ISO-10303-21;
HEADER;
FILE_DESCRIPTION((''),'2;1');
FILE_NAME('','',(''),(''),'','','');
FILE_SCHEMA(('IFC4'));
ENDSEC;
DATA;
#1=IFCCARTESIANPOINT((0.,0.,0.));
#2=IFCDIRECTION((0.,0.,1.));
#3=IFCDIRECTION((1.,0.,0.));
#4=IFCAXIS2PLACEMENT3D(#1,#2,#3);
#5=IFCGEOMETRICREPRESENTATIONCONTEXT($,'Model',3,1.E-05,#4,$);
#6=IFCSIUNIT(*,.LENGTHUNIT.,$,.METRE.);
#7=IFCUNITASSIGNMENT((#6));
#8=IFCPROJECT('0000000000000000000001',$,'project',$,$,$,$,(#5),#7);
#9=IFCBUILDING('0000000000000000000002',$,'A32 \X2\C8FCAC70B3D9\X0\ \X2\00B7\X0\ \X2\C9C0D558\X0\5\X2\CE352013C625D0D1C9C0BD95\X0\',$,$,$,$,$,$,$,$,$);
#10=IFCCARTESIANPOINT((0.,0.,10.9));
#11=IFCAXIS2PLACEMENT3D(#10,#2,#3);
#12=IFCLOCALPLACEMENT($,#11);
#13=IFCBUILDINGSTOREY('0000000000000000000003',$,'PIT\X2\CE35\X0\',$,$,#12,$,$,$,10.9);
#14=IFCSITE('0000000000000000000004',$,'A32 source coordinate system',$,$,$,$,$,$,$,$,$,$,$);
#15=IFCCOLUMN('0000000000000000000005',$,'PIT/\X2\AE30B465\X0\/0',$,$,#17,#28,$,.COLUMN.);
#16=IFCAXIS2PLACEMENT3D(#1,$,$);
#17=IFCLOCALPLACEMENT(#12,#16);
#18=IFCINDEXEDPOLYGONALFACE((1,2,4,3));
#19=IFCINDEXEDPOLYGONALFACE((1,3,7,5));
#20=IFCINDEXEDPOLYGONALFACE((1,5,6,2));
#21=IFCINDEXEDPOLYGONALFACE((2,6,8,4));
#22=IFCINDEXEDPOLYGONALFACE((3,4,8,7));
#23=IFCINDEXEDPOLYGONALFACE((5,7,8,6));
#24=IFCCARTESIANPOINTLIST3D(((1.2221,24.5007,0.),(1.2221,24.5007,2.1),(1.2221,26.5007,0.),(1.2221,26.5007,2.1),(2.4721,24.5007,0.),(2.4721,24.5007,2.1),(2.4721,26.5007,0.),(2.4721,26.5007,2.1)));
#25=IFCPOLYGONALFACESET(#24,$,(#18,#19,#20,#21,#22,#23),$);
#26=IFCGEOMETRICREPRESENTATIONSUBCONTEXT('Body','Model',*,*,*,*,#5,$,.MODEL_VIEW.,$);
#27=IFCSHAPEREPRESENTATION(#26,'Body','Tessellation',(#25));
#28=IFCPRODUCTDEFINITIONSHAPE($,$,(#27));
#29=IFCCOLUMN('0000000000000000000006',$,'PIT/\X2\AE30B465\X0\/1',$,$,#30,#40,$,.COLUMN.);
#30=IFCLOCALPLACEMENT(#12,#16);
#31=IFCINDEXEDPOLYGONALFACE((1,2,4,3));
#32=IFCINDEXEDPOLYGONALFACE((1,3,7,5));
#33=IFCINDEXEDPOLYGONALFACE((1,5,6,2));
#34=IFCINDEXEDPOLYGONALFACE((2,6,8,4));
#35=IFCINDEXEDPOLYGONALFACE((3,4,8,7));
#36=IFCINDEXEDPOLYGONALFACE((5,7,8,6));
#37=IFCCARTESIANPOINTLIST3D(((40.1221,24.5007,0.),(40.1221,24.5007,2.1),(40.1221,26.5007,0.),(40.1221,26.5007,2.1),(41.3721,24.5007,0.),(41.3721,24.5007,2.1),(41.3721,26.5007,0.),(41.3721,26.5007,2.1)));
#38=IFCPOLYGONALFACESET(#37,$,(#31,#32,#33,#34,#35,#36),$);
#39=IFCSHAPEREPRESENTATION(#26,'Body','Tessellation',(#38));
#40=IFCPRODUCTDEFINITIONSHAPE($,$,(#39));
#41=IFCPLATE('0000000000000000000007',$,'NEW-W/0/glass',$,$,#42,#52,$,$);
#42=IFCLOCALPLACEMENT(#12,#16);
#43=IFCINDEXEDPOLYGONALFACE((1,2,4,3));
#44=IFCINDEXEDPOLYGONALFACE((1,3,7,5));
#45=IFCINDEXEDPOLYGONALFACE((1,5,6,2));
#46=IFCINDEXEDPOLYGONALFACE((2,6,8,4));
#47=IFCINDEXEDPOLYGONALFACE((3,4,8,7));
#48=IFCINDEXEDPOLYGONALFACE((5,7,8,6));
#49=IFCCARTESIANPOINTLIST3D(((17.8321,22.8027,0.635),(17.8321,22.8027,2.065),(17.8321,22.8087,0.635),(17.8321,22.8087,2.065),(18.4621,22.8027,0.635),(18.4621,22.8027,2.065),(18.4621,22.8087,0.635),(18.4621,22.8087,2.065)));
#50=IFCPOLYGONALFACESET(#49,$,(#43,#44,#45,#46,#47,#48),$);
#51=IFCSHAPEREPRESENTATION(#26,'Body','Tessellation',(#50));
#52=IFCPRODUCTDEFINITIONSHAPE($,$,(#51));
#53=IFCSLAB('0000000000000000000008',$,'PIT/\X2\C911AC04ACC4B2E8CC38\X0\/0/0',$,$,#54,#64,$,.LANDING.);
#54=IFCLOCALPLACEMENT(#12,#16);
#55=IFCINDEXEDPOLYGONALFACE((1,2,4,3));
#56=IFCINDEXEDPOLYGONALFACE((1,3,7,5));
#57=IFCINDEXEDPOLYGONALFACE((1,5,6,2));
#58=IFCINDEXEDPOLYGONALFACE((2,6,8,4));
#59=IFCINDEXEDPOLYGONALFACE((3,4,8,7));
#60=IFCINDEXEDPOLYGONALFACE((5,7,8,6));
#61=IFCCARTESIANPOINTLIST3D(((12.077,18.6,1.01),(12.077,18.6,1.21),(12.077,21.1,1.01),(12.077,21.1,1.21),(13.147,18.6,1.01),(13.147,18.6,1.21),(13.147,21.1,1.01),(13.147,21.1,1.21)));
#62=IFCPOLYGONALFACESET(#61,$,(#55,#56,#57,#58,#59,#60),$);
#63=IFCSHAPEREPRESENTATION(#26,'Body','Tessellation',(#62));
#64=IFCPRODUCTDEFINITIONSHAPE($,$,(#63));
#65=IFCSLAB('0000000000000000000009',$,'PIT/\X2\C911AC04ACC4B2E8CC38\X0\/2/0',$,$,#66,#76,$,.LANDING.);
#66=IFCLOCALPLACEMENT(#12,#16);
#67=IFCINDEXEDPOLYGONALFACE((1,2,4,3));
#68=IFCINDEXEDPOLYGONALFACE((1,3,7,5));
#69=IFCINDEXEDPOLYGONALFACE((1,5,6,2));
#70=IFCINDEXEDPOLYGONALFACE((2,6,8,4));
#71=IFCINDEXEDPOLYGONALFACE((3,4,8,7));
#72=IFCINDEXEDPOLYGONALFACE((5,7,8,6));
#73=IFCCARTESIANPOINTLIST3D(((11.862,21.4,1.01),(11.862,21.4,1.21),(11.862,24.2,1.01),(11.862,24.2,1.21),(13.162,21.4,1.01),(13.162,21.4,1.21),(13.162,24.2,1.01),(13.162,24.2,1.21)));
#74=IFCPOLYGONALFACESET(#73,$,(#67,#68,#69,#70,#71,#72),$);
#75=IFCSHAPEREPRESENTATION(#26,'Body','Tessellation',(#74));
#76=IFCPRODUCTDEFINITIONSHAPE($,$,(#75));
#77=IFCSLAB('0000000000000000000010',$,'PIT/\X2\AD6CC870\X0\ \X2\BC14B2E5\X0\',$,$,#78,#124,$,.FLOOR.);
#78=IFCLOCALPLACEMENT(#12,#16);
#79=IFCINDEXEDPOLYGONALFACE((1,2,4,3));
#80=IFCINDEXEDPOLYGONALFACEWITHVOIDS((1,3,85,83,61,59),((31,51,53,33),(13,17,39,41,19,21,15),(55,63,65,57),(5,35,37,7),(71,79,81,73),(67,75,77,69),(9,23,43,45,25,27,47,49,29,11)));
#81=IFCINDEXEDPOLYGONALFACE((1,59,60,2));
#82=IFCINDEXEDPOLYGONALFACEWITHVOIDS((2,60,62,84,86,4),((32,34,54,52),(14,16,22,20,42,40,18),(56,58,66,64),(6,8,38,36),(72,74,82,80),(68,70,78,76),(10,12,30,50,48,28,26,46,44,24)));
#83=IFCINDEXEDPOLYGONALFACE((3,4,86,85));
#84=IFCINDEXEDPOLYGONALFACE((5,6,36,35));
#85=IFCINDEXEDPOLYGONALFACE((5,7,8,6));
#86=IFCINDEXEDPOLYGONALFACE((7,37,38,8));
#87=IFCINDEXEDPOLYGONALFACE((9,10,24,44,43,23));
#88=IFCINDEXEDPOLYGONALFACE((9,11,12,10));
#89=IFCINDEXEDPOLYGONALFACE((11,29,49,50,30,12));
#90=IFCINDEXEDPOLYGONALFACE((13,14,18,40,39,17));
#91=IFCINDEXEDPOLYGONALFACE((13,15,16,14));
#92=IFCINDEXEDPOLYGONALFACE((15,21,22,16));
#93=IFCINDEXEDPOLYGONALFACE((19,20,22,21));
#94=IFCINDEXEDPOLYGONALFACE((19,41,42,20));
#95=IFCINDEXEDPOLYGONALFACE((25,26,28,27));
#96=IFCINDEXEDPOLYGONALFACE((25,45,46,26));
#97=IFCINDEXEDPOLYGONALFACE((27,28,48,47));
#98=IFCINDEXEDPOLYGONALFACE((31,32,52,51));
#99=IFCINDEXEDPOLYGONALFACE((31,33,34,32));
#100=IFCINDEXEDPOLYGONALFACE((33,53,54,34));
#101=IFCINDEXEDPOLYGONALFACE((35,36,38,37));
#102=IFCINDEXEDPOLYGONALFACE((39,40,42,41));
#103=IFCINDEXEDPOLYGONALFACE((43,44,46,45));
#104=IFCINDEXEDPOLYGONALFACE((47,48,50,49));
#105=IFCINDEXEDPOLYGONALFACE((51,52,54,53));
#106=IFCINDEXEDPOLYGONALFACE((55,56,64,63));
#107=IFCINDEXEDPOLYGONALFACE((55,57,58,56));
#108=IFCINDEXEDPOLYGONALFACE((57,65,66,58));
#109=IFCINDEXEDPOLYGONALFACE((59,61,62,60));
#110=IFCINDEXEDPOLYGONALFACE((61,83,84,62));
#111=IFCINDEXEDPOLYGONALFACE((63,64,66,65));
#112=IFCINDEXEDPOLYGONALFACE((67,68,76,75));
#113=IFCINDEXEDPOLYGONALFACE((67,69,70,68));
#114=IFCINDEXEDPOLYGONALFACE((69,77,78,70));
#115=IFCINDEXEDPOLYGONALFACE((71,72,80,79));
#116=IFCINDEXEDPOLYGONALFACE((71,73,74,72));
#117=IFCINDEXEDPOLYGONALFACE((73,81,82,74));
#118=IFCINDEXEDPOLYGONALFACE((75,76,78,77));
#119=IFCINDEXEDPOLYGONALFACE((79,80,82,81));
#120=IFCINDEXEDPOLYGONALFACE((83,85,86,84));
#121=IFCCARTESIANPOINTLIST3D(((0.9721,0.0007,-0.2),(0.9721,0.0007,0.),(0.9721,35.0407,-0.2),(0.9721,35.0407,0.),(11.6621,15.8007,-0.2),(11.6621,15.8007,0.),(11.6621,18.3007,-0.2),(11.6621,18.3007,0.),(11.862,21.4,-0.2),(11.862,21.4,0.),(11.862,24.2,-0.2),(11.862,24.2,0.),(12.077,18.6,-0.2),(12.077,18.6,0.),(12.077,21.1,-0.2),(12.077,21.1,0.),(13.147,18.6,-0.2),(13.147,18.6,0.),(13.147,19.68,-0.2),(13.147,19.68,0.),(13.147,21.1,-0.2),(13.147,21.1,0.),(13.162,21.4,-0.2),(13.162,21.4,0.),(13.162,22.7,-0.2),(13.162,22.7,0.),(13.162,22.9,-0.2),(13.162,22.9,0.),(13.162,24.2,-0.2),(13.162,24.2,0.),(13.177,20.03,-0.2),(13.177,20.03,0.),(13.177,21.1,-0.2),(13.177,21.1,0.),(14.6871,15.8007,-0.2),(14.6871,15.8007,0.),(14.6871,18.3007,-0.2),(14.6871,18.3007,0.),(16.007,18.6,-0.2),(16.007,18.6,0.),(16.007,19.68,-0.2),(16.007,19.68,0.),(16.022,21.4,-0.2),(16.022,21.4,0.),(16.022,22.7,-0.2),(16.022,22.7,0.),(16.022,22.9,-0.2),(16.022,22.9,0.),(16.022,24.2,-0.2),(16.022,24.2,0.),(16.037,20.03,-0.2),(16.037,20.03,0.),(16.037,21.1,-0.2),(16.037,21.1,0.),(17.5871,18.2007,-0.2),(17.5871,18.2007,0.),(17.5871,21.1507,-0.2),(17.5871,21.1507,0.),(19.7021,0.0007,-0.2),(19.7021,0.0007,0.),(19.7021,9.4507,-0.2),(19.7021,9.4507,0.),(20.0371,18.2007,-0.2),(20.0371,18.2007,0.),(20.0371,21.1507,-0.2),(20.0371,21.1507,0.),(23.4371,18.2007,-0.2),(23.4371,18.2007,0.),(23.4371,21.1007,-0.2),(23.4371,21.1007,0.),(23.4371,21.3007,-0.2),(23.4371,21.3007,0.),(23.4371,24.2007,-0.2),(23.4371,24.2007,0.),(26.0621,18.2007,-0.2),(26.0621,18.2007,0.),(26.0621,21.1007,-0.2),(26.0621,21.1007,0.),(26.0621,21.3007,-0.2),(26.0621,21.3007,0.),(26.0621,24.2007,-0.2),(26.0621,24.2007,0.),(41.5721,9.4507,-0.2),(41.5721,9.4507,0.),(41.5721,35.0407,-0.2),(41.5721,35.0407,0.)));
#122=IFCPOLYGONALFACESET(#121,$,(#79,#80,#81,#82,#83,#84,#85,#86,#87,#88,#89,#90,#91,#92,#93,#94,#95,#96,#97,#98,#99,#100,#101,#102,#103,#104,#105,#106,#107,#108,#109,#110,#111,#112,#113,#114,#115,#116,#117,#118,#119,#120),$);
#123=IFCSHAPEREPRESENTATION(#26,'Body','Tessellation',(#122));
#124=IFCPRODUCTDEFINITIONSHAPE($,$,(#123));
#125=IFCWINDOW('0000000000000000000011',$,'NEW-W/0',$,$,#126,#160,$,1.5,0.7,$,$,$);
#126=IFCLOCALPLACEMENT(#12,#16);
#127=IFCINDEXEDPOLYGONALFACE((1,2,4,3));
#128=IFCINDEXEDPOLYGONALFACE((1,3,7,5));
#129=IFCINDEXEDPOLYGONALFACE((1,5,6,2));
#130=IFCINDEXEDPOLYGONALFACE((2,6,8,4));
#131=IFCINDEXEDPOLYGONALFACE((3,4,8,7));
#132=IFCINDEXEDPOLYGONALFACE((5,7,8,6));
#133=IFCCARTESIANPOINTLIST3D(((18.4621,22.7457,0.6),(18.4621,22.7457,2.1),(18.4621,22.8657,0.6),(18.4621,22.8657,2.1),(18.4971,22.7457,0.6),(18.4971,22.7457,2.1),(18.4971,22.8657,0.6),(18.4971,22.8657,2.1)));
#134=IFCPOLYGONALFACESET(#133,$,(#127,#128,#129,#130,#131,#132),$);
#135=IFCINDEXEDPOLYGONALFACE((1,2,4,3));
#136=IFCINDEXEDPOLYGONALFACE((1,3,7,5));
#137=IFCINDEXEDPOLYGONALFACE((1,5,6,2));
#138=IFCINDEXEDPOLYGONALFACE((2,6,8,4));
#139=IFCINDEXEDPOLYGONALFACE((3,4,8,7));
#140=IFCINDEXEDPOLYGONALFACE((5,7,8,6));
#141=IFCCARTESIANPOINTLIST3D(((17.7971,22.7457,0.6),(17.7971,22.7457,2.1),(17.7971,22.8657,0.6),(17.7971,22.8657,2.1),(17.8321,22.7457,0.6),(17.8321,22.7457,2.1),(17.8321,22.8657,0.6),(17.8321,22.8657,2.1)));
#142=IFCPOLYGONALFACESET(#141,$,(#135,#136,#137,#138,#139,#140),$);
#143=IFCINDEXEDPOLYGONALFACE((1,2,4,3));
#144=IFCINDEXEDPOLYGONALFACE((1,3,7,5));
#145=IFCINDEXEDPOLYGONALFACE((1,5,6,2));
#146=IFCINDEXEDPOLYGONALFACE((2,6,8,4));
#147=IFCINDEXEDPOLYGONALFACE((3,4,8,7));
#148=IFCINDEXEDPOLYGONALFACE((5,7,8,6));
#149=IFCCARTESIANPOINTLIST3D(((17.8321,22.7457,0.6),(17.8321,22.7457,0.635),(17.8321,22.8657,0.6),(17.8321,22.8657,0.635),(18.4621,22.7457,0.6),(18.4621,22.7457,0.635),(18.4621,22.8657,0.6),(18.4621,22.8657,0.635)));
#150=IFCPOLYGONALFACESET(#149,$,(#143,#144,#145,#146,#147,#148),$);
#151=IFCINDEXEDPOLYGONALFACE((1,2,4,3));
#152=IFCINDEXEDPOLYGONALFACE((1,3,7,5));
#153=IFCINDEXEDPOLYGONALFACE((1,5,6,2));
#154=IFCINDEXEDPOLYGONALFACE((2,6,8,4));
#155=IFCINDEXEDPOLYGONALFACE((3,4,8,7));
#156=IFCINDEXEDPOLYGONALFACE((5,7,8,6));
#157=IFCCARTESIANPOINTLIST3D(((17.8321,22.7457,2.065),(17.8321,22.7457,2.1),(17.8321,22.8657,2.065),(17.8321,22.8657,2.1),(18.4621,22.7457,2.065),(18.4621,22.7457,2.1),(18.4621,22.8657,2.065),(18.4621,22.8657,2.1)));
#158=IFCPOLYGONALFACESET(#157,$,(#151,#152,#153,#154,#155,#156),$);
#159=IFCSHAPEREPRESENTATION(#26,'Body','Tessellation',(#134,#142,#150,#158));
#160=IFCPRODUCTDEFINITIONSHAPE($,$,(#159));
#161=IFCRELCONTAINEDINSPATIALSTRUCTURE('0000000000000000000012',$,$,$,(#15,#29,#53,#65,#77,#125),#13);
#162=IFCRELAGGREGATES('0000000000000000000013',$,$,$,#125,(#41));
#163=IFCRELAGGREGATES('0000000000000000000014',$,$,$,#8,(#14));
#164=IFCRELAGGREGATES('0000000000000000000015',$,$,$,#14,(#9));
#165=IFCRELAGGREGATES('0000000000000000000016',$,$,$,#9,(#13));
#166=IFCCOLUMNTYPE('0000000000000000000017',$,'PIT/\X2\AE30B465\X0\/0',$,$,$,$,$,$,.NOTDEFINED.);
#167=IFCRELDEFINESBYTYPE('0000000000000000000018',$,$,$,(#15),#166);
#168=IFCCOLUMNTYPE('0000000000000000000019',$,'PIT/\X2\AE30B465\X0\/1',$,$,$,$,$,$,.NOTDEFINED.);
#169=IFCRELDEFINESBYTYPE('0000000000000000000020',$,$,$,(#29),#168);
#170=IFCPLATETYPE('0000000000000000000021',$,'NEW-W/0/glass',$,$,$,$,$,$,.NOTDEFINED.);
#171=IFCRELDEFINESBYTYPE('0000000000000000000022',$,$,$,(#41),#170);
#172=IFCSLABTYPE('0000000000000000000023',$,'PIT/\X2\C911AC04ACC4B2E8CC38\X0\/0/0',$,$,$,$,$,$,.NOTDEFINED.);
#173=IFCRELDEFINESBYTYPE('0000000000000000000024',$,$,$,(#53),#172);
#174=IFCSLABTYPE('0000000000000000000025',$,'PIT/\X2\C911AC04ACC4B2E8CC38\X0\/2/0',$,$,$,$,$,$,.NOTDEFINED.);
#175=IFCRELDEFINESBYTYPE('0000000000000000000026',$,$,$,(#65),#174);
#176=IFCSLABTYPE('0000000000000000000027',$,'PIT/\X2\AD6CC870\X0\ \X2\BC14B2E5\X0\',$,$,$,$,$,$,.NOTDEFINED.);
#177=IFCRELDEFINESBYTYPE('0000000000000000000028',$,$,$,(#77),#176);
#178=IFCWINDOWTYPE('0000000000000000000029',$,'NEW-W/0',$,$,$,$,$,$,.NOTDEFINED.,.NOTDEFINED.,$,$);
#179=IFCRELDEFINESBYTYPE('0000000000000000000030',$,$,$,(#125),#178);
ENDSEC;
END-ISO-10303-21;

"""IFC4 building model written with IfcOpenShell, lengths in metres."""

from ifc_helpers import new_model, si_unit, frame, origin, origin_with_axes, place, context, subcontext, project, spatial, polyline, outline, extrude, source, transform, mapped, type_object, type_shapes, element, aggregate, save


model = new_model("IFC4")

# Units and contexts
model_context = context("Model", 3, precision=1e-05, world=origin_with_axes())
body_context = subcontext(model_context, "Body", "Model", "MODEL_VIEW")
ifc_project = project(units=[si_unit("LENGTHUNIT", "METRE")], contexts=[model_context])

# Site, building, storey
site = spatial("IfcSite", under=ifc_project, Name="A32 source coordinate system")
building = spatial("IfcBuilding", under=site, Name="A32 주거동 · 지하5층–옥탑지붕")
storey_placement = place(None, frame((0.0, 0.0, 10.9), z_axis=(0.0, 0.0, 1.0), x_axis=(1.0, 0.0, 0.0)))
storey = spatial("IfcBuildingStorey", under=building, at=storey_placement, Name="PIT층", Elevation=10.9)

# Columns
column_type_1 = type_object("IfcColumnType", Name="PIT/기둥/0", PredefinedType="NOTDEFINED")
shared_shape_1 = source(origin(), body_context, "Body", "SweptSolid", [
    extrude(outline(polyline([(2.4721, 26.5007), (2.4721, 24.5007), (1.2221, 24.5007), (1.2221, 26.5007), (2.4721, 26.5007)])), origin(), (0.0, 0.0, 1.0), 2.1),
])
type_shapes(column_type_1, [shared_shape_1])
column_1_placement = place(storey_placement, origin_with_axes())
element("IfcColumn", 1, at=column_1_placement, inside=storey, type_object=column_type_1, Name="PIT/기둥/0", PredefinedType="COLUMN", context=body_context, shape_type="MappedRepresentation", body=[
    mapped(shared_shape_1, transform((0.0, 0.0, 0.0), scale=1.0)),
])
column_type_2 = type_object("IfcColumnType", Name="PIT/기둥/1", PredefinedType="NOTDEFINED")
shared_shape_2 = source(origin(), body_context, "Body", "SweptSolid", [
    extrude(outline(polyline([(41.3721, 24.5007), (40.1221, 24.5007), (40.1221, 26.5007), (41.3721, 26.5007), (41.3721, 24.5007)])), origin(), (0.0, 0.0, 1.0), 2.1),
])
type_shapes(column_type_2, [shared_shape_2])
column_2_placement = place(storey_placement, origin_with_axes())
element("IfcColumn", 2, at=column_2_placement, inside=storey, type_object=column_type_2, Name="PIT/기둥/1", PredefinedType="COLUMN", context=body_context, shape_type="MappedRepresentation", body=[
    mapped(shared_shape_2, transform((0.0, 0.0, 0.0), scale=1.0)),
])

# Plate
plate_type = type_object("IfcPlateType", Name="NEW-W/0/glass", PredefinedType="NOTDEFINED")
shared_shape_3 = source(origin(), body_context, "Body", "SweptSolid", [
    extrude(outline(polyline([(18.4621, 22.8027), (17.8321, 22.8027), (17.8321, 22.8087), (18.4621, 22.8087), (18.4621, 22.8027)])), frame((0.0, 0.0, 0.635)), (0.0, 0.0, 1.0), 1.43),
])
type_shapes(plate_type, [shared_shape_3])
window_placement = place(storey_placement, origin_with_axes())
plate_placement = place(window_placement, origin_with_axes())
plate = element("IfcPlate", 3, at=plate_placement, type_object=plate_type, Name="NEW-W/0/glass", context=body_context, shape_type="MappedRepresentation", body=[
    mapped(shared_shape_3, transform((0.0, 0.0, 0.0), scale=1.0)),
])

# Slabs
slab_type_1 = type_object("IfcSlabType", Name="PIT/중간계단참/0/0", PredefinedType="NOTDEFINED")
shared_shape_4 = source(origin(), body_context, "Body", "SweptSolid", [
    extrude(outline(polyline([(13.147, 18.6), (12.077, 18.6), (12.077, 21.1), (13.147, 21.1), (13.147, 18.6)])), frame((0.0, 0.0, 1.01)), (0.0, 0.0, 1.0), 0.2),
])
type_shapes(slab_type_1, [shared_shape_4])
slab_1_placement = place(storey_placement, origin_with_axes())
element("IfcSlab", 4, at=slab_1_placement, inside=storey, type_object=slab_type_1, Name="PIT/중간계단참/0/0", PredefinedType="LANDING", context=body_context, shape_type="MappedRepresentation", body=[
    mapped(shared_shape_4, transform((0.0, 0.0, 0.0), scale=1.0)),
])
slab_type_2 = type_object("IfcSlabType", Name="PIT/중간계단참/2/0", PredefinedType="NOTDEFINED")
shared_shape_5 = source(origin(), body_context, "Body", "SweptSolid", [
    extrude(outline(polyline([(13.162, 21.4), (11.862, 21.4), (11.862, 24.2), (13.162, 24.2), (13.162, 21.4)])), frame((0.0, 0.0, 1.01)), (0.0, 0.0, 1.0), 0.2),
])
type_shapes(slab_type_2, [shared_shape_5])
slab_2_placement = place(storey_placement, origin_with_axes())
element("IfcSlab", 5, at=slab_2_placement, inside=storey, type_object=slab_type_2, Name="PIT/중간계단참/2/0", PredefinedType="LANDING", context=body_context, shape_type="MappedRepresentation", body=[
    mapped(shared_shape_5, transform((0.0, 0.0, 0.0), scale=1.0)),
])
slab_type_3 = type_object("IfcSlabType", Name="PIT/구조 바닥", PredefinedType="NOTDEFINED")
shared_shape_6 = source(origin(), body_context, "Body", "SweptSolid", [
    extrude(outline(polyline([(41.5721, 9.4507), (19.7021, 9.4507), (19.7021, 0.0007), (0.9721, 0.0007), (0.9721, 35.0407), (41.5721, 35.0407), (41.5721, 9.4507)]), holes=[polyline([(26.0621, 18.2007), (26.0621, 18.2007), (26.0621, 21.1007), (26.0621, 21.1007), (26.0621, 21.1007), (23.4371, 21.1007), (23.4371, 21.1007), (23.4371, 18.2007), (23.4371, 18.2007), (26.0621, 18.2007), (26.0621, 18.2007)]), polyline([(26.0621, 24.2007), (26.0621, 24.2007), (23.4371, 24.2007), (23.4371, 24.2007), (23.4371, 24.2007), (23.4371, 21.3007), (23.4371, 21.3007), (23.4371, 21.3007), (26.0621, 21.3007), (26.0621, 21.3007), (26.0621, 21.3007), (26.0621, 24.2007), (26.0621, 24.2007)]), polyline([(17.5871, 18.2007), (17.5871, 18.2007), (20.0371, 18.2007), (20.0371, 21.1507), (17.5871, 21.1507), (17.5871, 21.1507), (17.5871, 21.1507), (17.5871, 18.2007), (17.5871, 18.2007)]), polyline([(13.177, 21.1), (13.177, 20.03), (16.037, 20.03), (16.037, 21.1), (13.177, 21.1)]), polyline([(13.162, 21.4), (16.022, 21.4), (16.022, 22.7), (13.162, 22.7), (13.162, 22.9), (16.022, 22.9), (16.022, 24.2), (13.162, 24.2), (11.862, 24.2), (11.862, 21.4), (13.162, 21.4), (13.162, 21.4)]), polyline([(13.147, 19.68), (13.147, 21.1), (12.077, 21.1), (12.077, 18.6), (13.147, 18.6), (16.007, 18.6), (16.007, 19.68), (13.147, 19.68)]), polyline([(14.6871, 18.3007), (14.6871, 18.3007), (11.6621, 18.3007), (11.6621, 18.3007), (11.6621, 15.8007), (11.6621, 15.8007), (14.6871, 15.8007), (14.6871, 15.8007), (14.6871, 18.3007)])]), frame((0.0, 0.0, -0.2)), (0.0, 0.0, 1.0), 0.2),
])
type_shapes(slab_type_3, [shared_shape_6])
slab_3_placement = place(storey_placement, origin_with_axes())
element("IfcSlab", 6, at=slab_3_placement, inside=storey, type_object=slab_type_3, Name="PIT/구조 바닥", PredefinedType="FLOOR", context=body_context, shape_type="MappedRepresentation", body=[
    mapped(shared_shape_6, transform((0.0, 0.0, 0.0), scale=1.0)),
])

# Window
window_type = type_object("IfcWindowType", Name="NEW-W/0", PartitioningType="NOTDEFINED", PredefinedType="NOTDEFINED")
shared_shape_7 = source(origin(), body_context, "Body", "SweptSolid", [
    extrude(outline(polyline([(18.4621, 22.7457), (18.4621, 22.8657), (18.4971, 22.8657), (18.4971, 22.7457), (18.4621, 22.7457)])), frame((0.0, 0.0, 0.6)), (0.0, 0.0, 1.0), 1.5),
    extrude(outline(polyline([(17.7971, 22.7457), (17.7971, 22.8657), (17.8321, 22.8657), (17.8321, 22.7457), (17.7971, 22.7457)])), frame((0.0, 0.0, 0.6)), (0.0, 0.0, 1.0), 1.5),
    extrude(outline(polyline([(18.4621, 22.7457), (18.4621, 22.8657), (17.8321, 22.8657), (17.8321, 22.7457), (18.4621, 22.7457)])), frame((0.0, 0.0, 0.6)), (0.0, 0.0, 1.0), 0.035),
    extrude(outline(polyline([(18.4621, 22.7457), (18.4621, 22.8657), (17.8321, 22.8657), (17.8321, 22.7457), (18.4621, 22.7457)])), frame((0.0, 0.0, 2.065)), (0.0, 0.0, 1.0), 0.035),
])
type_shapes(window_type, [shared_shape_7])
window = element("IfcWindow", 7, at=window_placement, inside=storey, type_object=window_type, Name="NEW-W/0", OverallHeight=1.5, OverallWidth=0.7, context=body_context, shape_type="MappedRepresentation", body=[
    mapped(shared_shape_7, transform((0.0, 0.0, 0.0), scale=1.0)),
])
aggregate(window, [plate])

save(model, "model.ifc")
